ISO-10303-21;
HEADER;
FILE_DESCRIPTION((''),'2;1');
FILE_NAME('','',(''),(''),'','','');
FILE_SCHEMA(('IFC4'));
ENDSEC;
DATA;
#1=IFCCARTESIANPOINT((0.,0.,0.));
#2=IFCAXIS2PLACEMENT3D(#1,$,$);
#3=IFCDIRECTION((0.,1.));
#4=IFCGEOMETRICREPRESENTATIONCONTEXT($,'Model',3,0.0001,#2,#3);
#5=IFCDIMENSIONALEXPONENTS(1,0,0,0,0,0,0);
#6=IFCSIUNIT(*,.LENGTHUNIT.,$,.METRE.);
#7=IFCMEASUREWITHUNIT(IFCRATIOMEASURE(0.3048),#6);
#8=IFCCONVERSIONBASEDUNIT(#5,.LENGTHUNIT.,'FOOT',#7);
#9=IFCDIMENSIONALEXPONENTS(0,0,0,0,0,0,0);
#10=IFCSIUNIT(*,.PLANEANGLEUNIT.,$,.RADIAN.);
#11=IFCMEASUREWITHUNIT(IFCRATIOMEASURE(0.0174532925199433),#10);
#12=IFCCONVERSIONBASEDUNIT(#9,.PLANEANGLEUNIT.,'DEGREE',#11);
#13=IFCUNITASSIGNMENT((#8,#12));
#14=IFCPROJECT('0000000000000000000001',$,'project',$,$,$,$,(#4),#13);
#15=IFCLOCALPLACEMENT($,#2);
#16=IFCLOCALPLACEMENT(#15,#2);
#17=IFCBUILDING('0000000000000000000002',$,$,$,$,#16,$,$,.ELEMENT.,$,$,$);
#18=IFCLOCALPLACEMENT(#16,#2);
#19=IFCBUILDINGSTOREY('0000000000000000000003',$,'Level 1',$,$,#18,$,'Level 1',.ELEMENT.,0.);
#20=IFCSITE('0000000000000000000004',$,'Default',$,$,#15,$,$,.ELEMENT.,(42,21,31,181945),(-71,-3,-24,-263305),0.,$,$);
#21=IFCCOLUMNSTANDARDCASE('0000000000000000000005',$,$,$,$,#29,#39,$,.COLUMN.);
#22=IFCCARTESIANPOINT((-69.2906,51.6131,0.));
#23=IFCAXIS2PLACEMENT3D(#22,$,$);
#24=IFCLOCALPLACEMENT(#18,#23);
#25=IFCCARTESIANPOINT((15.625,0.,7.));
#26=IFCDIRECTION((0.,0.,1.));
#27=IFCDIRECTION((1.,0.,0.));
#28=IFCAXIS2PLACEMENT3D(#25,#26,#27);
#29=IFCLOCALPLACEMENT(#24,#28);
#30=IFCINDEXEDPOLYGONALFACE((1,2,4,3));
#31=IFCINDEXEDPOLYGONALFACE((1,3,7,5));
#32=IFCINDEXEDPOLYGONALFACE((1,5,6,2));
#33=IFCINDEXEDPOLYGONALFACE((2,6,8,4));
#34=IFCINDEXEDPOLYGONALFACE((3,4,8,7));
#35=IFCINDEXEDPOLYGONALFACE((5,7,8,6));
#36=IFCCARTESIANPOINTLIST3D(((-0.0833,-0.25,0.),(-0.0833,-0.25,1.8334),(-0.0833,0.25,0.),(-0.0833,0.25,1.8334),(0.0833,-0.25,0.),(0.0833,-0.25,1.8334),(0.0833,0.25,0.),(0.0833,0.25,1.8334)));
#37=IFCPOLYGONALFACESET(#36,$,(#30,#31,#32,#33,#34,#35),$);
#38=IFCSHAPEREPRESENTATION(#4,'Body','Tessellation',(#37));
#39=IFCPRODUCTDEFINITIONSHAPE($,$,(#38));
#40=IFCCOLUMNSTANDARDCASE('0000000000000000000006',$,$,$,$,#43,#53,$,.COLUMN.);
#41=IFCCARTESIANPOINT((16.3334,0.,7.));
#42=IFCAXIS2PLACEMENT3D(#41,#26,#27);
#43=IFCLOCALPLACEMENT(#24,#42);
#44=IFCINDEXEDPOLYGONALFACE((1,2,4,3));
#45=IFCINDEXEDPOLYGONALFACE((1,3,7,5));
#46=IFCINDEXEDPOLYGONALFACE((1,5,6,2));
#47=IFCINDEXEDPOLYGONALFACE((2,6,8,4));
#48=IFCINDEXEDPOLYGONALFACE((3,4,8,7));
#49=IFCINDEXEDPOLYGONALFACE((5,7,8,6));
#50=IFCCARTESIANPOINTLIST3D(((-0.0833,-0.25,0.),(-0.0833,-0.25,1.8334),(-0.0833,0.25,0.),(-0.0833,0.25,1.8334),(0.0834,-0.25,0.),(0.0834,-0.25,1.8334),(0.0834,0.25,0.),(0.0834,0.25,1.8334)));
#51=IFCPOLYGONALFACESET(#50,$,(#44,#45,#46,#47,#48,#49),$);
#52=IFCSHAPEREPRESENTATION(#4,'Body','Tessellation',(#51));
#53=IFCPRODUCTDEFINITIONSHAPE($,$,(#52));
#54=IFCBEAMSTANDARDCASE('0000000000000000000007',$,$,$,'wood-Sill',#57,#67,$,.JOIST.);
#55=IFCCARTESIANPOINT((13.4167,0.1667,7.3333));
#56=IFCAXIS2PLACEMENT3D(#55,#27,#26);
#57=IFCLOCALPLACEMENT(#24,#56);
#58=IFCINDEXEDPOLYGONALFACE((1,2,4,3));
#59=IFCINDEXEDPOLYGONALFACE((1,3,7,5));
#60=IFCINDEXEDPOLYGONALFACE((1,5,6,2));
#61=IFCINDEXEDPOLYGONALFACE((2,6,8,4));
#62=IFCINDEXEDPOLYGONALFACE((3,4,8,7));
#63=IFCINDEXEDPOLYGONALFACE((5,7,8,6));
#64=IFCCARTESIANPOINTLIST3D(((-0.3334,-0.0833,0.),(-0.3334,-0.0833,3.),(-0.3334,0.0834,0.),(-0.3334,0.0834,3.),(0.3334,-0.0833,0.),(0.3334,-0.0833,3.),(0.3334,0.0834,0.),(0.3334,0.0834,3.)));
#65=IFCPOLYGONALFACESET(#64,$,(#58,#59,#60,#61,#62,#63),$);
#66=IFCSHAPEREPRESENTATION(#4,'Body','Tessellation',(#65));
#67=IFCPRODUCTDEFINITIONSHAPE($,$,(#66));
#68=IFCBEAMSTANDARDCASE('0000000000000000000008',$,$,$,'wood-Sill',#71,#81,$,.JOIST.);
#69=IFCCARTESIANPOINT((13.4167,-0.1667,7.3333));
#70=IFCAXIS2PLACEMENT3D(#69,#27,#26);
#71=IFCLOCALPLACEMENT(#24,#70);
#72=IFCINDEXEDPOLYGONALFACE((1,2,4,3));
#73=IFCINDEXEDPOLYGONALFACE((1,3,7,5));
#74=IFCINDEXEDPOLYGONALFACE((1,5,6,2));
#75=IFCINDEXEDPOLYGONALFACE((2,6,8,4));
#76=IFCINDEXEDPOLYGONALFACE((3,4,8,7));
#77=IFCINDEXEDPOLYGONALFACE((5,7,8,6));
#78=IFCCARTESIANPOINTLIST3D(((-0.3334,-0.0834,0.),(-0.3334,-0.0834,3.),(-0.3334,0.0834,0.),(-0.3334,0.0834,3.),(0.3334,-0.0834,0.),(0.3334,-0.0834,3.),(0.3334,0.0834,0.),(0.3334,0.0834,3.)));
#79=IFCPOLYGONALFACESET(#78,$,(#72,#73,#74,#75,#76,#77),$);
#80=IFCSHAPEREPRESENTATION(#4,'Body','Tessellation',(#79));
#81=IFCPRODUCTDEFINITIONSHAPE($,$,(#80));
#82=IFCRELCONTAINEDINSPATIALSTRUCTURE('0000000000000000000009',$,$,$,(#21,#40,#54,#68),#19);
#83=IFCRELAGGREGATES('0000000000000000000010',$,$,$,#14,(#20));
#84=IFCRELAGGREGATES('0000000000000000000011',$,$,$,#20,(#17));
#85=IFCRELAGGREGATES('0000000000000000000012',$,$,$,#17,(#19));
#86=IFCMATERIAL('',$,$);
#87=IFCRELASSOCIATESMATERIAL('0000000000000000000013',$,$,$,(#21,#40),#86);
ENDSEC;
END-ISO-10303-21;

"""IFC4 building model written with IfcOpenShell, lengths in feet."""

from ifc_helpers import new_model, entity, si_unit, converted_unit, direction, frame, origin, origin_with_axes, place, context, project, spatial, rectangle, extrude, material, element, save


model = new_model("IFC4")

# Units and contexts
model_context = context("Model", 3, precision=0.0001, world=origin(), true_north=direction((0.0, 1.0)))
ifc_project = project(units=[converted_unit("LENGTHUNIT", "FOOT", entity("IfcRatioMeasure", 0.3048), si_unit("LENGTHUNIT", "METRE"), dimensions=[1, 0, 0, 0, 0, 0, 0]), converted_unit("PLANEANGLEUNIT", "DEGREE", entity("IfcRatioMeasure", 0.0174532925199433), si_unit("PLANEANGLEUNIT", "RADIAN"), dimensions=[0, 0, 0, 0, 0, 0, 0])], contexts=[model_context])

# Site, building, storey
site_placement = place(None, origin())
site = spatial("IfcSite", under=ifc_project, at=site_placement, Name="Default", CompositionType="ELEMENT", RefLatitude=(42, 21, 31, 181945), RefLongitude=(-71, -3, -24, -263305), RefElevation=0.0)
building_placement = place(site_placement, origin())
building = spatial("IfcBuilding", under=site, at=building_placement, CompositionType="ELEMENT")
storey_placement = place(building_placement, origin())
storey = spatial("IfcBuildingStorey", under=building, at=storey_placement, Name="Level 1", LongName="Level 1", CompositionType="ELEMENT", Elevation=0.0)

# Columns
placement_1 = place(storey_placement, frame((-69.2906, 51.6131, 0.0)))
ifc_material_1 = material(Name="")
for number, where, z_axis, x_axis in (
    (1, (15.625, 0.0, 7.0), (0.0, 0.0, 1.0), (1.0, 0.0, 0.0)),
    (2, (16.3334, 0.0, 7.0), (0.0, 0.0, 1.0), (1.0, 0.0, 0.0)),
):
    element("IfcColumnStandardCase", number, at=place(placement_1, frame(where, z_axis=z_axis, x_axis=x_axis)), inside=storey, material=ifc_material_1, PredefinedType="COLUMN", context=model_context, shape_type="SweptSolid", body=[
        extrude(rectangle(XDim=0.1667, YDim=0.5), origin(), (0.0, 0.0, 1.0), 1.8334),
    ])

# Beams
for number, where, z_axis, x_axis in (
    (3, (13.4167, 0.1667, 7.3333), (1.0, 0.0, 0.0), (0.0, 0.0, 1.0)),
    (4, (13.4167, -0.1667, 7.3333), (1.0, 0.0, 0.0), (0.0, 0.0, 1.0)),
):
    element("IfcBeamStandardCase", number, at=place(placement_1, frame(where, z_axis=z_axis, x_axis=x_axis)), inside=storey, ObjectType="wood-Sill", PredefinedType="JOIST", context=model_context, shape_type="SweptSolid", body=[
        extrude(rectangle(XDim=0.6667, YDim=0.1667), origin_with_axes(), (0.0, 0.0, 1.0), 3.0),
    ])

save(model, "model.ifc")
